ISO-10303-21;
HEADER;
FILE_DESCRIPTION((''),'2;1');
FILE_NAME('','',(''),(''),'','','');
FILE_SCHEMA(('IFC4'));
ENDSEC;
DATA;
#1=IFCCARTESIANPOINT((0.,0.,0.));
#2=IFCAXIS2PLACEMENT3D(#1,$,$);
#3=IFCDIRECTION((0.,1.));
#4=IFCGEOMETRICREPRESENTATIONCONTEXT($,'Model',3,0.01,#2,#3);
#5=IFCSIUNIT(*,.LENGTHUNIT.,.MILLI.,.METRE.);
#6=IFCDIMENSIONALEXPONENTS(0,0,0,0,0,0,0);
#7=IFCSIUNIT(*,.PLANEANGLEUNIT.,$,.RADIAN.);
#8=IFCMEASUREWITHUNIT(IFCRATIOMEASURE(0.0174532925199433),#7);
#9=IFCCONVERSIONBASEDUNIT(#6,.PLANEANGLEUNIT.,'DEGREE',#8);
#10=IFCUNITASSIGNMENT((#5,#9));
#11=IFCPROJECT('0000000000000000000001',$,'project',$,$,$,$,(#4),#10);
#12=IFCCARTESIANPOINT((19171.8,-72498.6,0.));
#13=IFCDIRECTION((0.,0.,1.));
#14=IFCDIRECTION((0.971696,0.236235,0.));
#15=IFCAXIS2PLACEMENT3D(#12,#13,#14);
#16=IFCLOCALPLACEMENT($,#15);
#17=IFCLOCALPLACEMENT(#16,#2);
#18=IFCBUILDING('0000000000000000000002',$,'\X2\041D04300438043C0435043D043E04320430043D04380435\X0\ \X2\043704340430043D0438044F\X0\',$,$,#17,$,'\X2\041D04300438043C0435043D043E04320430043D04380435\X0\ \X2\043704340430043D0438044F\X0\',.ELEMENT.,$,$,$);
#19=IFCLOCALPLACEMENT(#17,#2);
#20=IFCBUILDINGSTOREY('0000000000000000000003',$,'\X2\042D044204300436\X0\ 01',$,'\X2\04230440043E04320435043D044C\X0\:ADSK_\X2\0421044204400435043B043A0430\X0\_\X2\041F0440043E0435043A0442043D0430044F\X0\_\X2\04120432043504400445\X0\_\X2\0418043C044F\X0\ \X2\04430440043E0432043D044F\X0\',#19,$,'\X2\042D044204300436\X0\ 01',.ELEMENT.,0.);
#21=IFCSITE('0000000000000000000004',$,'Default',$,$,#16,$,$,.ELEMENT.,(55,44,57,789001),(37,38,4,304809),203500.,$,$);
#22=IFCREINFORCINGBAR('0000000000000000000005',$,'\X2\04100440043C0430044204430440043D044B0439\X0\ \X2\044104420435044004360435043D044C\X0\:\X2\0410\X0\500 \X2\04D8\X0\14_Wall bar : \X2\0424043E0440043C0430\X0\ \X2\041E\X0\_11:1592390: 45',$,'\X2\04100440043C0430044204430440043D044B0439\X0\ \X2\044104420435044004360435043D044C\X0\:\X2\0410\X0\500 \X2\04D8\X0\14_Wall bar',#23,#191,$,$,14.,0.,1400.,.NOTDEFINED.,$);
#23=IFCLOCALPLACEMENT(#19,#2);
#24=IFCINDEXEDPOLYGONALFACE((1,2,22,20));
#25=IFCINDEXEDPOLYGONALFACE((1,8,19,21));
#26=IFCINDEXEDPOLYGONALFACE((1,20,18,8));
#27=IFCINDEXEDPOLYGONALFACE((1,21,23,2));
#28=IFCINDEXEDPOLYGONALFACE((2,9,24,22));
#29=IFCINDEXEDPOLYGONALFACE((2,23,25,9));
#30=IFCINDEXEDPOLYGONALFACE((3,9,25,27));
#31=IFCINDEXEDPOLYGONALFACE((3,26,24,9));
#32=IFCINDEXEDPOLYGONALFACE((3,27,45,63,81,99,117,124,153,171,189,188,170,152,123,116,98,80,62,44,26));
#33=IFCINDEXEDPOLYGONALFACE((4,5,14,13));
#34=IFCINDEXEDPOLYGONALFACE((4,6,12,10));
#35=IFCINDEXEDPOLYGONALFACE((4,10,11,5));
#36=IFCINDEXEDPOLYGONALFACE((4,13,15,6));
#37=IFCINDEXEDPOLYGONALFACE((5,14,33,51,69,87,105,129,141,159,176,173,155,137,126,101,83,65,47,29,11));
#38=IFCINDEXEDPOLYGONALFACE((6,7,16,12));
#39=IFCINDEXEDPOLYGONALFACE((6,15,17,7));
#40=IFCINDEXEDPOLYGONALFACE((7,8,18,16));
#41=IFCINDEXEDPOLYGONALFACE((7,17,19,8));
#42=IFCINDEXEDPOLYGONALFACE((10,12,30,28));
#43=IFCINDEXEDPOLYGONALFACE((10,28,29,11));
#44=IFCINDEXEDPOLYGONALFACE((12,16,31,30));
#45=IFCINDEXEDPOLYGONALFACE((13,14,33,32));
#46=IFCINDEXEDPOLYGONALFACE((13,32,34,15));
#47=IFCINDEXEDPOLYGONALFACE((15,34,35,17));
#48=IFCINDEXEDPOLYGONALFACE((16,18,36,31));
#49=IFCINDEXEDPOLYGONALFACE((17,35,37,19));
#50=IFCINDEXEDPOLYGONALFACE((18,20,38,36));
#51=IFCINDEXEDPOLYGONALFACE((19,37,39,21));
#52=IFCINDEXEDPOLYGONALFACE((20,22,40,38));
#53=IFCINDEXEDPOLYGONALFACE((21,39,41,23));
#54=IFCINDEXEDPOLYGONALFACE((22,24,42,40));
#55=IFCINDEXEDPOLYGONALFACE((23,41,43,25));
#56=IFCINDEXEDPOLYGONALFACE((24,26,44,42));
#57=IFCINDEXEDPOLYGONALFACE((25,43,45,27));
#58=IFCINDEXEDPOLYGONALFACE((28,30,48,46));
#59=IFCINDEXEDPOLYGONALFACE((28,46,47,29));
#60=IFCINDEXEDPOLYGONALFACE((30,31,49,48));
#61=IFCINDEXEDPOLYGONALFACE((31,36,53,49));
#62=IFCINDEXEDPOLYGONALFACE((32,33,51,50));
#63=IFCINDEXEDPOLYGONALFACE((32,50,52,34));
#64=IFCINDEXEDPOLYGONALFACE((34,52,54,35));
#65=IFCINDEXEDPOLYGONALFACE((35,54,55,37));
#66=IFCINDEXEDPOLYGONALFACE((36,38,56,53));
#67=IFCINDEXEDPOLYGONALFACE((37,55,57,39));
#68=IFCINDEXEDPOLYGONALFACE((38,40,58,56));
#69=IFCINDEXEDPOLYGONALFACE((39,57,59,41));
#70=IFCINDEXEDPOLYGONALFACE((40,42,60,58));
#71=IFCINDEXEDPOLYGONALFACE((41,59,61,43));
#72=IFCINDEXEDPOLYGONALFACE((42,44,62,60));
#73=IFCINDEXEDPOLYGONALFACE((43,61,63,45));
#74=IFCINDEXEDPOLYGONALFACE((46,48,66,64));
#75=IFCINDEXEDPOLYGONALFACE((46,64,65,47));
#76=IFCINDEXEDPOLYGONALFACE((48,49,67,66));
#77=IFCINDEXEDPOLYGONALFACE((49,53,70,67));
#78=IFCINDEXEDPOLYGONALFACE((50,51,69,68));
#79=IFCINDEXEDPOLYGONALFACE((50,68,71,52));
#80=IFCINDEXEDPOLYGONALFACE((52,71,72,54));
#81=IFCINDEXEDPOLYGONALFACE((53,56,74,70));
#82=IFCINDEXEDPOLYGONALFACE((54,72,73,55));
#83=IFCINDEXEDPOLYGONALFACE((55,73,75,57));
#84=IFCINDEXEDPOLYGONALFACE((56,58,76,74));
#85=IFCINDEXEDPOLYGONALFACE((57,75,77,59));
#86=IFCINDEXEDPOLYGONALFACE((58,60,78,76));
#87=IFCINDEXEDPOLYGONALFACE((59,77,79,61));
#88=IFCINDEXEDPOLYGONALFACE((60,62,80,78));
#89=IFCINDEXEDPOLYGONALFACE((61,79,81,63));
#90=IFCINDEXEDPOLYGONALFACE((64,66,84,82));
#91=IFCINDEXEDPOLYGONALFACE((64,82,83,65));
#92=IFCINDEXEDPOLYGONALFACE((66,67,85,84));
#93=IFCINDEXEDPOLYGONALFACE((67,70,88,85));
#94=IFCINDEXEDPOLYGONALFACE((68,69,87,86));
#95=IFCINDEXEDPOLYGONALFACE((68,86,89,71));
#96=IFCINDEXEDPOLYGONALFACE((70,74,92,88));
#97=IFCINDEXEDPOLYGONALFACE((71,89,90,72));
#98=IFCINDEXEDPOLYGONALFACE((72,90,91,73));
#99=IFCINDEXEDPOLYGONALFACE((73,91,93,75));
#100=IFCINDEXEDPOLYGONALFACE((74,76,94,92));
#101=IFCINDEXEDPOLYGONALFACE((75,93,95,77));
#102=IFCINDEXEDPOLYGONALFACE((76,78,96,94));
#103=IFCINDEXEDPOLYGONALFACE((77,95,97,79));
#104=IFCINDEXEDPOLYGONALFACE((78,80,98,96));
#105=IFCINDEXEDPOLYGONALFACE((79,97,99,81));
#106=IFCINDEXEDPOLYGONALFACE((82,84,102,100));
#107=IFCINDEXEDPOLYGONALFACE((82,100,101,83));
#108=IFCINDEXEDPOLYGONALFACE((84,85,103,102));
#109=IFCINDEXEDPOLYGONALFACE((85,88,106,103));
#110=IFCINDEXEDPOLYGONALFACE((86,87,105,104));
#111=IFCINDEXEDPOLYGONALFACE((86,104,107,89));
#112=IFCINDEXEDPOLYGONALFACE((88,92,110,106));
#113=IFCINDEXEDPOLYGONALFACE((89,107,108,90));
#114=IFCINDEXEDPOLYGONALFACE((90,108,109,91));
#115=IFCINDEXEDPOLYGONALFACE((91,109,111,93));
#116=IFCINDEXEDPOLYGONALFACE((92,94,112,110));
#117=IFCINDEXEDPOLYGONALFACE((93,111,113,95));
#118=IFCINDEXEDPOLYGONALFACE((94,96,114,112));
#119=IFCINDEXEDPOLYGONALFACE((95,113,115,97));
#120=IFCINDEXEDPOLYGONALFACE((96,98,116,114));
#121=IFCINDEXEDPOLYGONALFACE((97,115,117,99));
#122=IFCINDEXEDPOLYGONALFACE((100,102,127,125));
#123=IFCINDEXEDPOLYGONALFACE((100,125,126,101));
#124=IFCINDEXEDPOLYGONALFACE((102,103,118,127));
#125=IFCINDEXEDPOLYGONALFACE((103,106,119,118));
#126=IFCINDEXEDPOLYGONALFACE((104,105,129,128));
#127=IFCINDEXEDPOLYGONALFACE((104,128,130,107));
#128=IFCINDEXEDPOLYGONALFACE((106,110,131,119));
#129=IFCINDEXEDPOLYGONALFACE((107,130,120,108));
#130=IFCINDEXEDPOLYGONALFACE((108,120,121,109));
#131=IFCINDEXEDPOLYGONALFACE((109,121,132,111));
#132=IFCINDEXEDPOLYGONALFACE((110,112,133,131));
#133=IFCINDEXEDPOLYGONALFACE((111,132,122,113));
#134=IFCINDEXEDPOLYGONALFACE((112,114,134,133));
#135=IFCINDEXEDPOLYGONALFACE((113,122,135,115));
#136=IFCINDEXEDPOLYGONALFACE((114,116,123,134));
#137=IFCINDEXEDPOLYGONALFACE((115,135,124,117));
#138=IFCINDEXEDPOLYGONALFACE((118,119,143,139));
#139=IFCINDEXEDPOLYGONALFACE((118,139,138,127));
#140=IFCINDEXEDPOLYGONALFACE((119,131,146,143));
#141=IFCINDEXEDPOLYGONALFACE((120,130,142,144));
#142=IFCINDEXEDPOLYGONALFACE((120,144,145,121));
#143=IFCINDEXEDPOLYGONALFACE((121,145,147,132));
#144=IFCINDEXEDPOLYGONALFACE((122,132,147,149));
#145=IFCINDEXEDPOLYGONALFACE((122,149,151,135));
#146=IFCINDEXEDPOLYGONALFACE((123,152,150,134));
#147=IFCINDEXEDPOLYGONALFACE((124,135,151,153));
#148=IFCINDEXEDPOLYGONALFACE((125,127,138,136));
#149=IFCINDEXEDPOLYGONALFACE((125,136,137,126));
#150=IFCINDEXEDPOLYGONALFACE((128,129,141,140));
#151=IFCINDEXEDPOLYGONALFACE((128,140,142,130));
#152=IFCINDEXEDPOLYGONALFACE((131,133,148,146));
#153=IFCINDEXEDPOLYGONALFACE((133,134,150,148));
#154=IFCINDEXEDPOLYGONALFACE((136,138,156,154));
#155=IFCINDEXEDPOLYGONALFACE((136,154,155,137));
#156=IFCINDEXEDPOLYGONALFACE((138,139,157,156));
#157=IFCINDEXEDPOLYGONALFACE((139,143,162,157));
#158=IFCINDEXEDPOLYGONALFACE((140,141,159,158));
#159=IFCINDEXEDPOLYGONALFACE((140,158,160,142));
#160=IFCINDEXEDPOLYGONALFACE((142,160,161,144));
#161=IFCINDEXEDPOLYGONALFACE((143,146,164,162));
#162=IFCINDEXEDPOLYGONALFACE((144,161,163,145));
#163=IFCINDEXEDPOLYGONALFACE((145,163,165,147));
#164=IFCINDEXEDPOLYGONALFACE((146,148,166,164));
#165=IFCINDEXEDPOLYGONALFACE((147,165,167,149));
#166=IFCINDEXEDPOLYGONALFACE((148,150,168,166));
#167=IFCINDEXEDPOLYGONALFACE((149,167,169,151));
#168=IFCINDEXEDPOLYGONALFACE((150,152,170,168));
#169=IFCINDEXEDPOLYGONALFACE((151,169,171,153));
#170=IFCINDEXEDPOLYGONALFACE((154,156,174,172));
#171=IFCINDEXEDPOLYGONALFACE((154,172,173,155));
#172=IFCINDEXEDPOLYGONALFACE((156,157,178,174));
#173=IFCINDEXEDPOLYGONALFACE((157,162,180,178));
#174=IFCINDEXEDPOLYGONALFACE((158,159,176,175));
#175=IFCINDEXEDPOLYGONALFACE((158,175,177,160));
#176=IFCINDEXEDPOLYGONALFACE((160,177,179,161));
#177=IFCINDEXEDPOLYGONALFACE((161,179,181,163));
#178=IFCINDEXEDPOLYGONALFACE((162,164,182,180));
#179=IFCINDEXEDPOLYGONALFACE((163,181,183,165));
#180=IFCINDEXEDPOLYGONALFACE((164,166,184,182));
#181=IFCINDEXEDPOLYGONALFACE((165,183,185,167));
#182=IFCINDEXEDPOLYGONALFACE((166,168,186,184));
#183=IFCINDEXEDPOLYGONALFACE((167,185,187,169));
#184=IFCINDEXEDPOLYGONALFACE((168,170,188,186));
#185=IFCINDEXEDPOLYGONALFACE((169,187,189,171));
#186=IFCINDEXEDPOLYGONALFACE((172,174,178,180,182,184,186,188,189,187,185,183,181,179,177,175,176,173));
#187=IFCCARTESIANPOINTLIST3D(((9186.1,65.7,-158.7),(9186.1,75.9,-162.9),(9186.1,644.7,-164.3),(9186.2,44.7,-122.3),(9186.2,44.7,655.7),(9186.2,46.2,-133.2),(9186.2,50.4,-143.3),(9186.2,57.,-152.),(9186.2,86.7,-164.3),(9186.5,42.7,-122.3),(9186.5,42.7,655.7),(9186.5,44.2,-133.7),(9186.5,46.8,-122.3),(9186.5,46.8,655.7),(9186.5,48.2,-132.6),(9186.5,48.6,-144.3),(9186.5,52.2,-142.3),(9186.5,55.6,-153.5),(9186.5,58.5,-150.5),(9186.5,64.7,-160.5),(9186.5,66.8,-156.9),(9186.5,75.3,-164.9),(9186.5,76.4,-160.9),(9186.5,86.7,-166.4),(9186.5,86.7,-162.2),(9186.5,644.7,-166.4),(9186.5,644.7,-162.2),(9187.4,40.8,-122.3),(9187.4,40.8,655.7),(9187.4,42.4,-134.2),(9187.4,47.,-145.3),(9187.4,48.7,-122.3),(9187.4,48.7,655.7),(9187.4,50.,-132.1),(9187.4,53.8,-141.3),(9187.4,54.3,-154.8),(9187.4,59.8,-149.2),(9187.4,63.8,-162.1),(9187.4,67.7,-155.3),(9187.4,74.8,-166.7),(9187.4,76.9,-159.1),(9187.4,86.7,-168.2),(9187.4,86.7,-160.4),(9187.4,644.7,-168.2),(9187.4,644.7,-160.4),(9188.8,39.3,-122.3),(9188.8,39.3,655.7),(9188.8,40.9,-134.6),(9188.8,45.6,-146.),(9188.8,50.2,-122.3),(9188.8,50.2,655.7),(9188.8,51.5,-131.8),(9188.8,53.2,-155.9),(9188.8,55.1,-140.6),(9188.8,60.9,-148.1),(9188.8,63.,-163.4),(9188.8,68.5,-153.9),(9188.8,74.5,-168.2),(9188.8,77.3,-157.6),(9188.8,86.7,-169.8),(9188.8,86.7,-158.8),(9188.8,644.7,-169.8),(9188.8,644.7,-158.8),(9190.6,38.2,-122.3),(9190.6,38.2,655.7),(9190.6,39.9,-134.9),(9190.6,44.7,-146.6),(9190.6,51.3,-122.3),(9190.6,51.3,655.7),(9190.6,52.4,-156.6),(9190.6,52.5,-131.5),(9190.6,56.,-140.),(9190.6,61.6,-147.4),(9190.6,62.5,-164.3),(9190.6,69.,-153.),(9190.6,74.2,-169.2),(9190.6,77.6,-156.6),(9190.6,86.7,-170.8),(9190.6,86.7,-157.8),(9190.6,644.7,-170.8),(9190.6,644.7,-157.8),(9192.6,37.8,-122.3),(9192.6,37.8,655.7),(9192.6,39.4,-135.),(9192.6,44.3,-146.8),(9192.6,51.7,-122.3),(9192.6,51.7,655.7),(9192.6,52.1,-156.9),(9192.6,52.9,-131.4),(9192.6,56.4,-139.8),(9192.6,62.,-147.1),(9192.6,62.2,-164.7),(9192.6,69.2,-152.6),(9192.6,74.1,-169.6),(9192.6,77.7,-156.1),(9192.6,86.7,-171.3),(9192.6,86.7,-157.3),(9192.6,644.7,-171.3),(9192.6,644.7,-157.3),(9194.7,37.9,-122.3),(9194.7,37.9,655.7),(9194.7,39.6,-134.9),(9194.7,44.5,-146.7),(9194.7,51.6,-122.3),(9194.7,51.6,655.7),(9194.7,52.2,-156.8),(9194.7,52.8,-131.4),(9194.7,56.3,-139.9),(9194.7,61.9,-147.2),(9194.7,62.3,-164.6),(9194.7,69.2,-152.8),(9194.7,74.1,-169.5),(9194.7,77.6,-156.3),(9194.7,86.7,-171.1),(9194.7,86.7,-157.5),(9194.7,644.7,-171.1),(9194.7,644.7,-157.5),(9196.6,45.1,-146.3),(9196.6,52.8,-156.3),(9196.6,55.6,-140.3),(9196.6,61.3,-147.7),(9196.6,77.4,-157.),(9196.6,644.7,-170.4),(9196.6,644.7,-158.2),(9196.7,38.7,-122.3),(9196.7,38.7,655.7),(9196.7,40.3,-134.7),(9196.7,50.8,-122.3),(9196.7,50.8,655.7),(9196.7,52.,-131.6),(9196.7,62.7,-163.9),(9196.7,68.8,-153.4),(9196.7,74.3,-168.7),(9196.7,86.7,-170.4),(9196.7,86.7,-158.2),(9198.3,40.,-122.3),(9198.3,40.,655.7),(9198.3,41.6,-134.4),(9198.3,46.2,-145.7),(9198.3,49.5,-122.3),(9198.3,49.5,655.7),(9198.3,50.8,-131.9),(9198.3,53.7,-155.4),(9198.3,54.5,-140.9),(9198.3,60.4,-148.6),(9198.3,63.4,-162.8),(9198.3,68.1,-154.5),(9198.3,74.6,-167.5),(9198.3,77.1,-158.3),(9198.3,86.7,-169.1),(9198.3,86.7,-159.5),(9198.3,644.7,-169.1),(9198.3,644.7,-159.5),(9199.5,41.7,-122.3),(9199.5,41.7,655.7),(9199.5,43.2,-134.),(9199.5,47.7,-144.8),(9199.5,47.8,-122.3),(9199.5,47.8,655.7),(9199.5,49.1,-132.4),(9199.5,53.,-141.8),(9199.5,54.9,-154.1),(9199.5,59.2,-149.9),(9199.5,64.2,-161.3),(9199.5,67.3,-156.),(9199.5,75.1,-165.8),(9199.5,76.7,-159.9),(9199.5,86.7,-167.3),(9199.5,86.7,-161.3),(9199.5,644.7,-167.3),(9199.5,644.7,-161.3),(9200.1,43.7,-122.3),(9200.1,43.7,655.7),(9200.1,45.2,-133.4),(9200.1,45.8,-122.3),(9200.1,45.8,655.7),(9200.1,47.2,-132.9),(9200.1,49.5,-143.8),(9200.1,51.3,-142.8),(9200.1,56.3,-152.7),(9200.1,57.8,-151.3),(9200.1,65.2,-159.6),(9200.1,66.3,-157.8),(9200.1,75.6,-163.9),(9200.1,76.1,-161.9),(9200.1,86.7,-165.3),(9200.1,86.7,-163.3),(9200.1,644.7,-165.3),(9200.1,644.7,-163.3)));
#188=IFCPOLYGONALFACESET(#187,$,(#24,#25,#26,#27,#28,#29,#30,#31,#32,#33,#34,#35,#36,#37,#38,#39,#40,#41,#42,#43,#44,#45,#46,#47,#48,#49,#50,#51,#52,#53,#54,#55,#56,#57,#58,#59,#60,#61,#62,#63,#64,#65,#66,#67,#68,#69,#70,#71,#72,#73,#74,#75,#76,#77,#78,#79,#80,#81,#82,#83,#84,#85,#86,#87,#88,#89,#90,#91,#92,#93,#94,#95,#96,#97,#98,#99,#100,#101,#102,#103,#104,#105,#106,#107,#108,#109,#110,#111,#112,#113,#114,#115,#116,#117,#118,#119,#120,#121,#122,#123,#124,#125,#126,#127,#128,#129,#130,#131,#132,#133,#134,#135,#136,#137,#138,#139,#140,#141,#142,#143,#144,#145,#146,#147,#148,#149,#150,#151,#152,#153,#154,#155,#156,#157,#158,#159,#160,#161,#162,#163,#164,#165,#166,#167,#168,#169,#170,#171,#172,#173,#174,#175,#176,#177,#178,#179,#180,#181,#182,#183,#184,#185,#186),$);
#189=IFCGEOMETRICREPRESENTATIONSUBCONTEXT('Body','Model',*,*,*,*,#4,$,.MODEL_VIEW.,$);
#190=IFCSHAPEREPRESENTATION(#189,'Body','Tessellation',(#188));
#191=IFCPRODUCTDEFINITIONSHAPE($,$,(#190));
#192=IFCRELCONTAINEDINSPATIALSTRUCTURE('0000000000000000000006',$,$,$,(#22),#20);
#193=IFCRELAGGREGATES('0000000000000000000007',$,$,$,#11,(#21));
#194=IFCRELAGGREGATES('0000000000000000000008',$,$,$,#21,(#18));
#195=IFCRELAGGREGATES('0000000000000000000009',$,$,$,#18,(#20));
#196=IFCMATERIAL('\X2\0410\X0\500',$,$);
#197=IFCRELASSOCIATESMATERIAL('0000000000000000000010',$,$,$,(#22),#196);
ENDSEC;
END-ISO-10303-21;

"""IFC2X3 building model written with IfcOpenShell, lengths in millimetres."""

from ifc_helpers import new_model, entity, si_unit, converted_unit, direction, frame, origin, place, context, subcontext, project, spatial, material, element, save


model = new_model("IFC2X3")

# Units and contexts
model_context = context("Model", 3, precision=0.01, world=origin(), true_north=direction((0.0, 1.0)))
body_context = subcontext(model_context, "Body", "Model", "MODEL_VIEW")
ifc_project = project(units=[si_unit("LENGTHUNIT", "METRE", prefix="MILLI"), converted_unit("PLANEANGLEUNIT", "DEGREE", entity("IfcRatioMeasure", 0.0174532925199433), si_unit("PLANEANGLEUNIT", "RADIAN"), dimensions=[0, 0, 0, 0, 0, 0, 0])], contexts=[model_context])

# Site, building, storey
site_placement = place(None, frame((19171.8, -72498.6, 0.0), z_axis=(0.0, 0.0, 1.0), x_axis=(0.971696, 0.236235, 0.0)))
site = spatial("IfcSite", under=ifc_project, at=site_placement, Name="Default", CompositionType="ELEMENT", RefLatitude=(55, 44, 57, 789001), RefLongitude=(37, 38, 4, 304809), RefElevation=203500.0)
building_placement = place(site_placement, origin())
building = spatial("IfcBuilding", under=site, at=building_placement, Name="Наименование здания", LongName="Наименование здания", CompositionType="ELEMENT")
storey_placement = place(building_placement, origin())
storey = spatial("IfcBuildingStorey", under=building, at=storey_placement, Name="Этаж 01", ObjectType="Уровень:ADSK_Стрелка_Проектная_Вверх_Имя уровня", LongName="Этаж 01", CompositionType="ELEMENT", Elevation=0.0)

# Reinforcing bar
ifc_material = material(Name="А500")
placement = place(storey_placement, origin())
element("IfcReinforcingBar", 1, at=placement, inside=storey, material=ifc_material, Name="Арматурный стержень:А500 Ә14_Wall bar : Форма О_11:1592390: 45", ObjectType="Арматурный стержень:А500 Ә14_Wall bar", BarLength=1400.0, BarRole="NOTDEFINED", CrossSectionArea=0.0, NominalDiameter=14.0, context=body_context, shape_type="AdvancedSweptSolid", body=[
    entity("IfcSweptDiskSolid", entity("IfcCompositeCurve", [entity("IfcCompositeCurveSegment", "CONTINUOUS", True, entity("IfcPolyline", [entity("IfcCartesianPoint", [9193.1, 44.7, 655.7]), entity("IfcCartesianPoint", [9193.1, 44.7, -122.3])])), entity("IfcCompositeCurveSegment", "CONTINUOUS", True, entity("IfcTrimmedCurve", entity("IfcCircle", entity("IfcAxis2Placement3D", entity("IfcCartesianPoint", [9193.1, 86.7, -122.3]), entity("IfcDirection", [1.0, 0.0, 0.0]), entity("IfcDirection", [0.0, 0.0, -1.0])), 42.0), [entity("IfcParameterValue", 270.0)], [entity("IfcParameterValue", 360.0)], True, "PARAMETER")), entity("IfcCompositeCurveSegment", "CONTINUOUS", True, entity("IfcPolyline", [entity("IfcCartesianPoint", [9193.1, 86.7, -164.3]), entity("IfcCartesianPoint", [9193.1, 644.7, -164.3])]))], False), 7.0, None, 0.0, 92.0),
])

save(model, "model.ifc")
